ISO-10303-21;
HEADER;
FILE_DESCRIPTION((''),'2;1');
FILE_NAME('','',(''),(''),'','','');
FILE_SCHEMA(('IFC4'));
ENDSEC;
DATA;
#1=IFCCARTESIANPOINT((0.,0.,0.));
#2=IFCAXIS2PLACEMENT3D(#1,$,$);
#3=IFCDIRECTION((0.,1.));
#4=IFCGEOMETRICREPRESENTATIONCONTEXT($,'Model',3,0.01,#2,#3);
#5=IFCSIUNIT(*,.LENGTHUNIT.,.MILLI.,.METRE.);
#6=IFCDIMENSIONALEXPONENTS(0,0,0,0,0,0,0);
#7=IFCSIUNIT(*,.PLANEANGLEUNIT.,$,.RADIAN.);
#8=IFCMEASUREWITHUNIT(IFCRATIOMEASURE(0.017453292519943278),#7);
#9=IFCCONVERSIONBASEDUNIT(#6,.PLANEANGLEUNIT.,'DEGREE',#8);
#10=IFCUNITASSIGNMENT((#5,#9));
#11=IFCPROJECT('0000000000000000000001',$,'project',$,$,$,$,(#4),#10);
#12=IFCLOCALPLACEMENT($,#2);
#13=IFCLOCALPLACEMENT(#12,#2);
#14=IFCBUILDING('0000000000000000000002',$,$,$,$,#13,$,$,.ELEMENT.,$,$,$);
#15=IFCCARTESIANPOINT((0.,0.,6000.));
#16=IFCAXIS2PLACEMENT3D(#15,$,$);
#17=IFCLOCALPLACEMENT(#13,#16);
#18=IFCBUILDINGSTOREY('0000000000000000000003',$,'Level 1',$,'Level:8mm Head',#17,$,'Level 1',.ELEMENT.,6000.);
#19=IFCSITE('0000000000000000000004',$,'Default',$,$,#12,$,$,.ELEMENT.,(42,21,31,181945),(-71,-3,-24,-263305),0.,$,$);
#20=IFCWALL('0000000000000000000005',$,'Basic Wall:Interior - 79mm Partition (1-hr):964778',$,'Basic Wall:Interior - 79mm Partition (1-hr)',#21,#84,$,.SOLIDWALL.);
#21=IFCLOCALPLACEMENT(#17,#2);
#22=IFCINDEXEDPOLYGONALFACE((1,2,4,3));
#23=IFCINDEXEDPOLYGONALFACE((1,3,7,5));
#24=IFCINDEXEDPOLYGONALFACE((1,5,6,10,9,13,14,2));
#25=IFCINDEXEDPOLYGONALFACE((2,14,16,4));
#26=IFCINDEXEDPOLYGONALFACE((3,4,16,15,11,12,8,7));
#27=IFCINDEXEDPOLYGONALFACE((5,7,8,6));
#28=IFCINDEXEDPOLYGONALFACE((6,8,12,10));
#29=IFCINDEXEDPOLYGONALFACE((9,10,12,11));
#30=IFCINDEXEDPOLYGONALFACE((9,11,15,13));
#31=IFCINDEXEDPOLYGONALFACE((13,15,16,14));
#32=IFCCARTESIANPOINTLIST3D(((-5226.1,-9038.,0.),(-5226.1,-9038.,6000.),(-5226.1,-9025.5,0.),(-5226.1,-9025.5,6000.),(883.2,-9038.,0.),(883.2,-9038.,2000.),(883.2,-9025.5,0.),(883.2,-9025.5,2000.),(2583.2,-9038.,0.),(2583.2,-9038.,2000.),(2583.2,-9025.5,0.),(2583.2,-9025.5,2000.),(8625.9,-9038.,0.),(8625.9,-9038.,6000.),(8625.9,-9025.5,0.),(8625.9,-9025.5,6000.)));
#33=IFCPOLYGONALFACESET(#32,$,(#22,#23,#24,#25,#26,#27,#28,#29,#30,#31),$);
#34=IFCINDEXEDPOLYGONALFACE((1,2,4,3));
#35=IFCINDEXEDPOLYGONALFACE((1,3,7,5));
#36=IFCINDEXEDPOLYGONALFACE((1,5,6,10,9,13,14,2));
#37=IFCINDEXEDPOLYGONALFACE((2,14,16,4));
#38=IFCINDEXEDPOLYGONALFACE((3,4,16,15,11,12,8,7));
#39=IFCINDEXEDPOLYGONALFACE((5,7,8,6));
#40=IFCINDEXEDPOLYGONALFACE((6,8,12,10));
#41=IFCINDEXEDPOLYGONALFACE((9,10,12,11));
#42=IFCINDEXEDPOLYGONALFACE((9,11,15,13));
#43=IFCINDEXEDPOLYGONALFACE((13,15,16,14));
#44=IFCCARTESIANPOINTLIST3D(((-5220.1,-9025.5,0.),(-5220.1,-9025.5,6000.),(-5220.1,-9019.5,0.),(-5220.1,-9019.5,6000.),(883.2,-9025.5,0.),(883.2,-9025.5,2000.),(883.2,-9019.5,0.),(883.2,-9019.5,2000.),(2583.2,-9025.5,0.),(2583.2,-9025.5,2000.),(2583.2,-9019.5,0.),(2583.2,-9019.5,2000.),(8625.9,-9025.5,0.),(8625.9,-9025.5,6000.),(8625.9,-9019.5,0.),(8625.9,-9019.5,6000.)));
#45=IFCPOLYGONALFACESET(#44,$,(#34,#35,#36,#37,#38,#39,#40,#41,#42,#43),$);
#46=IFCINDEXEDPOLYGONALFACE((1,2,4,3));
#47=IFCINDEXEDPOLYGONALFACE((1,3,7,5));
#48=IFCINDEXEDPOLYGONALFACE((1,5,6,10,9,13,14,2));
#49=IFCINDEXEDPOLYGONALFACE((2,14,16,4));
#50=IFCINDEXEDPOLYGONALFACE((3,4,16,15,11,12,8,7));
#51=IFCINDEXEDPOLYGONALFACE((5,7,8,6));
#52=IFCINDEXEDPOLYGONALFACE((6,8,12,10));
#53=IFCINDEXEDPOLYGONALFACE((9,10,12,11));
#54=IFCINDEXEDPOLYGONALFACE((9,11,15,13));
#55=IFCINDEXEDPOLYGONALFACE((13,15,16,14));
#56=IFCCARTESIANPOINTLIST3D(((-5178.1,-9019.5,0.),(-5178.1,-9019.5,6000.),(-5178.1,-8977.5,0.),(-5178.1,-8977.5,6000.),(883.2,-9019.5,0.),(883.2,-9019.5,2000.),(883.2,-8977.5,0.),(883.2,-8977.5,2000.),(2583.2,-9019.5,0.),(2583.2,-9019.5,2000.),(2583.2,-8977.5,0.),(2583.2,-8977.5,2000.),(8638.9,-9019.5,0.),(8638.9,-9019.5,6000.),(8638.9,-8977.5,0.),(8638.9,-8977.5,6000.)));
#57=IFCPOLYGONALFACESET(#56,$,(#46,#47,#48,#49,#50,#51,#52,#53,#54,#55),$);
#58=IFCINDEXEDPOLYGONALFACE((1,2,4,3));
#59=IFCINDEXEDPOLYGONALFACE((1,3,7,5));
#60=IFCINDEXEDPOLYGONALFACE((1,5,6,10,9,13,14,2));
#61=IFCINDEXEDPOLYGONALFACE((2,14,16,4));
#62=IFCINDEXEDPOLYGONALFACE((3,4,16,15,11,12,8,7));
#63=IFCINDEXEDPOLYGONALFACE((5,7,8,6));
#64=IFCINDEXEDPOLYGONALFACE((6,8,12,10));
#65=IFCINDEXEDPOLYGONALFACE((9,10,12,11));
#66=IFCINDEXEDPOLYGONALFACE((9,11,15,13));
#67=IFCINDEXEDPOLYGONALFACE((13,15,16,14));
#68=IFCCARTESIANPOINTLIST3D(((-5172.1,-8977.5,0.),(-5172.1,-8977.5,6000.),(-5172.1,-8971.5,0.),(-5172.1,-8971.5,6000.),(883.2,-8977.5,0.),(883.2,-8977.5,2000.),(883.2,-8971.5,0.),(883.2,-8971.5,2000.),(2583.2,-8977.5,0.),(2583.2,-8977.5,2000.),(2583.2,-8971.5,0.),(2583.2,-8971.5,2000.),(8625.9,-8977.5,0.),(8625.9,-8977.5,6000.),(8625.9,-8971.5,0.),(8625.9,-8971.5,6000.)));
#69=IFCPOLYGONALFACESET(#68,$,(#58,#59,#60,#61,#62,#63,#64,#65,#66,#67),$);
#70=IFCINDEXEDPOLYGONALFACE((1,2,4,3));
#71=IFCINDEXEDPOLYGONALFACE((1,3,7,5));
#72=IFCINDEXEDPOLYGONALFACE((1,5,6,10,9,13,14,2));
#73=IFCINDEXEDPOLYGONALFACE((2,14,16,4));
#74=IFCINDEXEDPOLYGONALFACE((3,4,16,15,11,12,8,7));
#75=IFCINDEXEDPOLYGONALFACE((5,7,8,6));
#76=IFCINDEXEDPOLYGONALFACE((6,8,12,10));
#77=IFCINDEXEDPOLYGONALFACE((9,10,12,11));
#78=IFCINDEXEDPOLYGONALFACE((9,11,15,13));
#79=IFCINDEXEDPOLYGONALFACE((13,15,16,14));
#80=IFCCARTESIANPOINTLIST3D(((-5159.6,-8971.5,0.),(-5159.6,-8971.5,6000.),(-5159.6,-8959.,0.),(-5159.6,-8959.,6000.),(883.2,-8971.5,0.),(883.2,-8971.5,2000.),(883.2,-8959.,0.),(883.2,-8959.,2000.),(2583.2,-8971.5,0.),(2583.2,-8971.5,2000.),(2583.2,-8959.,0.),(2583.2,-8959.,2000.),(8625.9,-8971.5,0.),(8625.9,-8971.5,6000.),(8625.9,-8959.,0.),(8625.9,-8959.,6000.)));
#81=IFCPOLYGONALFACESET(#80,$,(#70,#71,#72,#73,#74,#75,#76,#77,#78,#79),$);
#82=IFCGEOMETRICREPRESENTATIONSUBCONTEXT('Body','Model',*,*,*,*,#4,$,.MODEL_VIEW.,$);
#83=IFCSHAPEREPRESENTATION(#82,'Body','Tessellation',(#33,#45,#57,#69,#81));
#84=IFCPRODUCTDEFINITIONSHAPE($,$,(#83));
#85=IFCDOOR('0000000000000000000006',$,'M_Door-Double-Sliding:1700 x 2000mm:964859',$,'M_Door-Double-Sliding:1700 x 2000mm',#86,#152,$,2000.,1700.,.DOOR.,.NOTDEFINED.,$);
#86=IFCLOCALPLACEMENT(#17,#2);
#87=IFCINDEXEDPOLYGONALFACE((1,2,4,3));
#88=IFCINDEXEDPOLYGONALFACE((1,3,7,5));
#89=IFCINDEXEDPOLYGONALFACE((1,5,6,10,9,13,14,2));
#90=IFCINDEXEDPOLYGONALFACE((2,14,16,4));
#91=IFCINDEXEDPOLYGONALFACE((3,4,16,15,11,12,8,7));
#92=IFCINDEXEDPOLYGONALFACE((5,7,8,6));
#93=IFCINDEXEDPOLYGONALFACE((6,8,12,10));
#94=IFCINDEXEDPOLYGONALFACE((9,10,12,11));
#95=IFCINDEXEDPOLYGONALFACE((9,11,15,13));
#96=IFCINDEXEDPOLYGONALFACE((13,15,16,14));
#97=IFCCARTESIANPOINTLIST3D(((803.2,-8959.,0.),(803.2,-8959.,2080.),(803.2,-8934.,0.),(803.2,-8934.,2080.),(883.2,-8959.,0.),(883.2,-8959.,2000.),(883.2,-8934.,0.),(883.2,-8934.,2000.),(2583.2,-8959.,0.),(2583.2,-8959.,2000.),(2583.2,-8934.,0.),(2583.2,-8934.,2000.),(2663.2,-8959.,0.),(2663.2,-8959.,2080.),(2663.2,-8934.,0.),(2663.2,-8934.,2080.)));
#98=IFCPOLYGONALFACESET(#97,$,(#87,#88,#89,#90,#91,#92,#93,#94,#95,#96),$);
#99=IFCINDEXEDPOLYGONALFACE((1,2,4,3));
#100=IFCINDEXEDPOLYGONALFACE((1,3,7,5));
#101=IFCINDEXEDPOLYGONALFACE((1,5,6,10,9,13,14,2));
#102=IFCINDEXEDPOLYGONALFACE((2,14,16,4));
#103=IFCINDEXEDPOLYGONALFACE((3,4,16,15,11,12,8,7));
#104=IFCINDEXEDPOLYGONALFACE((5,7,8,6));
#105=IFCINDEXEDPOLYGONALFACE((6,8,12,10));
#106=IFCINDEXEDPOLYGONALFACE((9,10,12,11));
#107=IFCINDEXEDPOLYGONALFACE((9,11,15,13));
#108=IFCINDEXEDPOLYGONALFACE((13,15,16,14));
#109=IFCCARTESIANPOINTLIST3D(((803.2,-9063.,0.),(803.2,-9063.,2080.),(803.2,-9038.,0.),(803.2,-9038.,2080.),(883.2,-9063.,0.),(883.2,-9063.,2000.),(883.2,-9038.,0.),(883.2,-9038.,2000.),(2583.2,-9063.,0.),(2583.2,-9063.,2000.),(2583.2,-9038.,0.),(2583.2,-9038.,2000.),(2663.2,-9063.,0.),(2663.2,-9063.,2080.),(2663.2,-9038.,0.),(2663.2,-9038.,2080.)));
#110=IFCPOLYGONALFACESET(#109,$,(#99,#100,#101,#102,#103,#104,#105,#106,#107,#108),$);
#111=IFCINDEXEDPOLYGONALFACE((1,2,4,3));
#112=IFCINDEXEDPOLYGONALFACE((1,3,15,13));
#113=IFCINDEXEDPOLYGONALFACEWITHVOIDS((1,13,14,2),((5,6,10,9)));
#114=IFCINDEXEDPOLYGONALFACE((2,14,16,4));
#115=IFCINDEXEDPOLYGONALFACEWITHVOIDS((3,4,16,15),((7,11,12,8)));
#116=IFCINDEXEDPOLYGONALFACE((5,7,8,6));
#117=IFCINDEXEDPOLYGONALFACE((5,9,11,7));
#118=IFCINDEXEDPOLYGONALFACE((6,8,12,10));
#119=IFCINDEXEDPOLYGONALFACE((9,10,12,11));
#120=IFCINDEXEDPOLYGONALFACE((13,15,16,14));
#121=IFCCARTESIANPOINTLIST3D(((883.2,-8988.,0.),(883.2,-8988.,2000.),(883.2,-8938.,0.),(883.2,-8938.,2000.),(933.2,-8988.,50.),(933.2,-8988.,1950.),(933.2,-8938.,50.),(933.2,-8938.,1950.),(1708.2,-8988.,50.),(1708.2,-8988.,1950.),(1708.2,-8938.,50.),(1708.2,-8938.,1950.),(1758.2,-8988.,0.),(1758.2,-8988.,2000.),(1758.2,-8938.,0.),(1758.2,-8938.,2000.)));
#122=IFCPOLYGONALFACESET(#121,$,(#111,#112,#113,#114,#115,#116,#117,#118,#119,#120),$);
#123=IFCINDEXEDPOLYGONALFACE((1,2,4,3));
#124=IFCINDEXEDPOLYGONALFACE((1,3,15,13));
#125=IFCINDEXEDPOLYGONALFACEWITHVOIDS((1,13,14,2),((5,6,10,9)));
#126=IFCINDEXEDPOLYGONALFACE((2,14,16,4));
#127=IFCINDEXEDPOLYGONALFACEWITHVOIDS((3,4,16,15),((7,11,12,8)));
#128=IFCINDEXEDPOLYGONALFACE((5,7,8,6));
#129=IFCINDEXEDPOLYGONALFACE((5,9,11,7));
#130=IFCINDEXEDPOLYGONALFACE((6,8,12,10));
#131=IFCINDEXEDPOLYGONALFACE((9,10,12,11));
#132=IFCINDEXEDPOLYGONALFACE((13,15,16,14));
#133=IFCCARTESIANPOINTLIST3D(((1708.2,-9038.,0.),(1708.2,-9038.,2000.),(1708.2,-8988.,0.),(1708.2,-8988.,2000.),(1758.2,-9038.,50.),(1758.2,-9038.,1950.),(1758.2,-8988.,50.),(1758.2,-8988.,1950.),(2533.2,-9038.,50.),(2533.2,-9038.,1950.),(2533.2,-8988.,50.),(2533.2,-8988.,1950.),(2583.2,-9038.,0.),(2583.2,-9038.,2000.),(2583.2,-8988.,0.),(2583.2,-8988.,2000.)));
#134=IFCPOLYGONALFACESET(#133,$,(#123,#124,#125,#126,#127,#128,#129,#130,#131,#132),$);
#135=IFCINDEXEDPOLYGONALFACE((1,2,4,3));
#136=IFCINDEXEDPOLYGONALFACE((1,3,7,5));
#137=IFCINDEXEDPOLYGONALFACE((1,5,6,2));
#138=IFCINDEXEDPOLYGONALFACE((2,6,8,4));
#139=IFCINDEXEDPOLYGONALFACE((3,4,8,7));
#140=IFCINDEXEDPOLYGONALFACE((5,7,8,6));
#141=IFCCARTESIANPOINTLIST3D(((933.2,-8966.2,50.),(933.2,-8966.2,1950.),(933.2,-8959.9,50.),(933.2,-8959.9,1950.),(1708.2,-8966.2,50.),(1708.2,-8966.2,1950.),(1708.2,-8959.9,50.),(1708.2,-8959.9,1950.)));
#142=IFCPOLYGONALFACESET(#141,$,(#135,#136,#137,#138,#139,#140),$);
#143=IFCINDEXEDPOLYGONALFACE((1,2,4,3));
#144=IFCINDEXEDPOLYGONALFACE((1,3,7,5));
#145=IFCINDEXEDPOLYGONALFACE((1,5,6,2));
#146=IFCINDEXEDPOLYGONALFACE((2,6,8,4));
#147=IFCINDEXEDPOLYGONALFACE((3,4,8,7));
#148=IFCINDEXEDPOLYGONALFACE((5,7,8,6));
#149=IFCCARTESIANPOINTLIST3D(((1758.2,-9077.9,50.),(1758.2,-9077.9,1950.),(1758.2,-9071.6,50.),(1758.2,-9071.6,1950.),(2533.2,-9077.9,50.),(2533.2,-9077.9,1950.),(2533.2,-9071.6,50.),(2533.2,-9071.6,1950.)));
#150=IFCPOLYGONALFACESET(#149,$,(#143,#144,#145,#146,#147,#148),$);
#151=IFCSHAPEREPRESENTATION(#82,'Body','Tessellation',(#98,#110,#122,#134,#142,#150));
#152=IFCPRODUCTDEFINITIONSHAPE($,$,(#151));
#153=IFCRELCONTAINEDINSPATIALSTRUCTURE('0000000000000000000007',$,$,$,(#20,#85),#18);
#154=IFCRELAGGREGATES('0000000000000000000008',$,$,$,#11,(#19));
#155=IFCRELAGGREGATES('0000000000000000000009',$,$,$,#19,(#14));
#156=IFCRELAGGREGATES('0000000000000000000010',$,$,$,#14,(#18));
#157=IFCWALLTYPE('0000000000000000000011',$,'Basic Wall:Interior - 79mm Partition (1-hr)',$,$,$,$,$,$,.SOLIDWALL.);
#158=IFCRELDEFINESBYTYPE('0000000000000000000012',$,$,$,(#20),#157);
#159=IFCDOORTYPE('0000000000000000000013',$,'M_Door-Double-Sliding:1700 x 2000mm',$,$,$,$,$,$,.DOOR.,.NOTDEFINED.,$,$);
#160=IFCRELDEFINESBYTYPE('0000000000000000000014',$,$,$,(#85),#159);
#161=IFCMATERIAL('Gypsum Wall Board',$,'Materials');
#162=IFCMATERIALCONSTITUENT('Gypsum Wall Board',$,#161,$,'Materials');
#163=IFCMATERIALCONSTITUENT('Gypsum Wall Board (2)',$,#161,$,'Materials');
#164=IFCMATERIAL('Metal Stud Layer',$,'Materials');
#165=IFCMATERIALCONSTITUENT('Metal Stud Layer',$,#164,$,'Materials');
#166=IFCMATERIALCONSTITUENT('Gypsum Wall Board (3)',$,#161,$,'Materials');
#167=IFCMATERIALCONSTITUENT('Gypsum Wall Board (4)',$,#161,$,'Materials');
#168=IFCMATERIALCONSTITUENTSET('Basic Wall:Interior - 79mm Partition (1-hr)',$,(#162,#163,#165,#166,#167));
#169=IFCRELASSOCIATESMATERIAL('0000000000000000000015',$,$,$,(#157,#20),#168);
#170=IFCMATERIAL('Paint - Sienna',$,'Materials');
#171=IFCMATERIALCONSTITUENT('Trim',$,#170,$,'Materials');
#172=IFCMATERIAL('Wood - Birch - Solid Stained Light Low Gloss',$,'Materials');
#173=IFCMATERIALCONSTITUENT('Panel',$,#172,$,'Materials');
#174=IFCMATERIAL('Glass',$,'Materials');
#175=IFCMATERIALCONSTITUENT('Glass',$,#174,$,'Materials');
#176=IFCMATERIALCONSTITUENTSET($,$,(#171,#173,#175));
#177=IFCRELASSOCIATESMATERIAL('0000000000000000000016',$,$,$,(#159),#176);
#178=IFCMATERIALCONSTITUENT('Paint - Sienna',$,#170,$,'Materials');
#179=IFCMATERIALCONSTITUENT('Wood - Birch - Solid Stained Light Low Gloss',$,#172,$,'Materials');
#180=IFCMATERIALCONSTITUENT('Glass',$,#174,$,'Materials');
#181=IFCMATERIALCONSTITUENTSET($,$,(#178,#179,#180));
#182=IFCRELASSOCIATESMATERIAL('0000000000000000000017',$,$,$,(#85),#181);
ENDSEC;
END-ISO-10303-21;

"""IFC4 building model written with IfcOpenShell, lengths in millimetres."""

from ifc_helpers import new_model, entity, si_unit, converted_unit, direction, frame, origin, place, context, subcontext, project, spatial, indexed_curve, outline, extrude, source, transform, mapped, material, constituent, constituent_set, type_object, type_shapes, element, fill, save


model = new_model("IFC4")

# Units and contexts
model_context = context("Model", 3, precision=0.01, world=origin(), true_north=direction((0.0, 1.0)))
body_context = subcontext(model_context, "Body", "Model", "MODEL_VIEW")
ifc_project = project(units=[si_unit("LENGTHUNIT", "METRE", prefix="MILLI"), converted_unit("PLANEANGLEUNIT", "DEGREE", entity("IfcRatioMeasure", 0.017453292519943278), si_unit("PLANEANGLEUNIT", "RADIAN"), dimensions=[0, 0, 0, 0, 0, 0, 0])], contexts=[model_context])

# Site, building, storey
site_placement = place(None, origin())
site = spatial("IfcSite", under=ifc_project, at=site_placement, Name="Default", CompositionType="ELEMENT", RefLatitude=(42, 21, 31, 181945), RefLongitude=(-71, -3, -24, -263305), RefElevation=0.0)
building_placement = place(site_placement, origin())
building = spatial("IfcBuilding", under=site, at=building_placement, CompositionType="ELEMENT")
storey_placement = place(building_placement, frame((0.0, 0.0, 6000.0)))
storey = spatial("IfcBuildingStorey", under=building, at=storey_placement, Name="Level 1", ObjectType="Level:8mm Head", LongName="Level 1", CompositionType="ELEMENT", Elevation=6000.0)

# Shared definitions
ifc_material_1 = material(Name="Gypsum Wall Board", Category="Materials")
ifc_constituent_1 = constituent(ifc_material_1, Name="Gypsum Wall Board", Category="Materials")
ifc_constituent_2 = constituent(ifc_material_1, Name="Gypsum Wall Board (2)", Category="Materials")
ifc_material_2 = material(Name="Metal Stud Layer", Category="Materials")
ifc_constituent_3 = constituent(ifc_material_2, Name="Metal Stud Layer", Category="Materials")
ifc_constituent_4 = constituent(ifc_material_1, Name="Gypsum Wall Board (3)", Category="Materials")
ifc_constituent_5 = constituent(ifc_material_1, Name="Gypsum Wall Board (4)", Category="Materials")
ifc_constituent_set_1 = constituent_set(constituents=[ifc_constituent_1, ifc_constituent_2, ifc_constituent_3, ifc_constituent_4, ifc_constituent_5], Name="Basic Wall:Interior - 79mm Partition (1-hr)")
wall_type = type_object("IfcWallType", Name="Basic Wall:Interior - 79mm Partition (1-hr)", PredefinedType="SOLIDWALL", material=ifc_constituent_set_1)

# Wall, opening, door
ifc_material_3 = material(Name="Paint - Sienna", Category="Materials")
ifc_material_4 = material(Name="Wood - Birch - Solid Stained Light Low Gloss", Category="Materials")
ifc_material_5 = material(Name="Glass", Category="Materials")
ifc_constituent_6 = constituent(ifc_material_3, Name="Trim", Category="Materials")
ifc_constituent_7 = constituent(ifc_material_4, Name="Panel", Category="Materials")
ifc_constituent_8 = constituent(ifc_material_5, Name="Glass", Category="Materials")
ifc_constituent_set_2 = constituent_set(constituents=[ifc_constituent_6, ifc_constituent_7, ifc_constituent_8])
door_type = type_object("IfcDoorType", Name="M_Door-Double-Sliding:1700 x 2000mm", OperationType="NOTDEFINED", PredefinedType="DOOR", material=ifc_constituent_set_2)
shared_shape_1 = source(origin(), body_context, "Body", "SweptSolid", [
    extrude(outline(indexed_curve([(-1020.0, -930.0), (1060.0, -930.0), (1060.0, 930.0), (-1020.0, 930.0), (-1020.0, 850.0), (980.0, 850.0), (980.0, -850.0), (-1020.0, -850.0), (-1020.0, -930.0)], self_intersect=False)), frame((850.0, -25.0, 1020.0), z_axis=(0.0, 1.0, 0.0), x_axis=(0.0, 0.0, 1.0)), (0.0, 0.0, 1.0), 25.0),
    extrude(outline(indexed_curve([(-930.0, -1020.0), (-850.0, -1020.0), (-850.0, 980.0), (850.0, 980.0), (850.0, -1020.0), (930.0, -1020.0), (930.0, 1060.0), (-930.0, 1060.0), (-930.0, -1020.0)], self_intersect=False)), frame((850.0, 79.0, 1020.0), z_axis=(0.0, 1.0, 0.0), x_axis=(-1.0, 0.0, 0.0)), (0.0, 0.0, 1.0), 25.0),
    extrude(outline(indexed_curve([(-437.5, -1000.0), (437.5, -1000.0), (437.5, 1000.0), (-437.5, 1000.0), (-437.5, -1000.0)], self_intersect=False), holes=[indexed_curve([(-387.5, -950.0), (-387.5, 950.0), (387.5, 950.0), (387.5, -950.0), (-387.5, -950.0)], self_intersect=False)]), frame((1262.5, -21.0, 1000.0), z_axis=(0.0, 1.0, 0.0), x_axis=(1.0, 0.0, 0.0)), (0.0, 0.0, 1.0), 50.0),
    extrude(outline(indexed_curve([(-1000.0, -437.5), (1000.0, -437.5), (1000.0, 437.5), (-1000.0, 437.5), (-1000.0, -437.5)], self_intersect=False), holes=[indexed_curve([(-950.0, -387.5), (-950.0, 387.5), (950.0, 387.5), (950.0, -387.5), (-950.0, -387.5)], self_intersect=False)]), frame((437.5, 29.0, 1000.0), z_axis=(0.0, 1.0, 0.0), x_axis=(0.0, 0.0, -1.0)), (0.0, 0.0, 1.0), 50.0),
    extrude(outline(indexed_curve([(-3.2, -387.5), (3.2, -387.5), (3.2, 387.5), (-3.2, 387.5), (-3.2, -387.5)], self_intersect=False)), frame((1262.5, 4.0, 50.0), z_axis=(0.0, 0.0, 1.0), x_axis=(0.0, -1.0, 0.0)), (0.0, 0.0, 1.0), 1900.0),
    extrude(outline(indexed_curve([(-3.2, -387.5), (3.2, -387.5), (3.2, 387.5), (-3.2, 387.5), (-3.2, -387.5)], self_intersect=False)), frame((437.5, 115.7, 50.0), z_axis=(0.0, 0.0, 1.0), x_axis=(0.0, 1.0, 0.0)), (0.0, 0.0, 1.0), 1900.0),
])
type_shapes(door_type, [shared_shape_1])
wall_1_placement = place(storey_placement, frame((-5159.6, -8998.5, 0.0)))
wall_1 = element("IfcWall", 1, at=wall_1_placement, inside=storey, type_object=wall_type, material=ifc_constituent_set_1, Name="Basic Wall:Interior - 79mm Partition (1-hr):964778", ObjectType="Basic Wall:Interior - 79mm Partition (1-hr)", PredefinedType="SOLIDWALL", context=body_context, shape_type="SweptSolid", body=[
    extrude(outline(indexed_curve([(-2000.0, -6942.6), (4000.0, -6942.6), (4000.0, 6909.4), (-2000.0, 6909.4), (-2000.0, 866.6), (0.0, 866.6), (0.0, -833.4), (-2000.0, -833.4), (-2000.0, -6942.6)], self_intersect=False)), frame((6876.1, -39.5, 2000.0), z_axis=(0.0, 1.0, 0.0), x_axis=(0.0, 0.0, 1.0)), (0.0, 0.0, 1.0), 12.5),
    extrude(outline(indexed_curve([(-2000.0, -865.1), (-2000.0, -6907.9), (4000.0, -6907.9), (4000.0, 6938.1), (-2000.0, 6938.1), (-2000.0, 834.9), (0.0, 834.9), (0.0, -865.1), (-2000.0, -865.1)], self_intersect=False)), frame((6877.6, -27.0, 2000.0), z_axis=(0.0, -1.0, 0.0), x_axis=(0.0, 0.0, 1.0)), (0.0, 0.0, -1.0), 6.0),
    extrude(outline(indexed_curve([(-2000.0, -851.4), (-2000.0, -6907.1), (4000.0, -6907.1), (4000.0, 6909.9), (-2000.0, 6909.9), (-2000.0, 848.6), (0.0, 848.6), (0.0, -851.4), (-2000.0, -851.4)], self_intersect=False)), frame((6891.4, -21.0, 2000.0), z_axis=(0.0, -1.0, 0.0), x_axis=(0.0, 0.0, 1.0)), (0.0, 0.0, -1.0), 42.0),
    extrude(outline(indexed_curve([(-2000.0, -853.1), (-2000.0, -6895.9), (4000.0, -6895.9), (4000.0, 6902.1), (-2000.0, 6902.1), (-2000.0, 846.9), (0.0, 846.9), (0.0, -853.1), (-2000.0, -853.1)], self_intersect=False)), frame((6889.6, 21.0, 2000.0), z_axis=(0.0, -1.0, 0.0), x_axis=(0.0, 0.0, 1.0)), (0.0, 0.0, -1.0), 6.0),
    extrude(outline(indexed_curve([(-2000.0, -850.0), (-2000.0, -6892.8), (4000.0, -6892.8), (4000.0, 6892.8), (-2000.0, 6892.8), (-2000.0, 850.0), (0.0, 850.0), (0.0, -850.0), (-2000.0, -850.0)], self_intersect=False)), frame((6892.8, 27.0, 2000.0), z_axis=(0.0, -1.0, 0.0), x_axis=(0.0, 0.0, 1.0)), (0.0, 0.0, -1.0), 12.5),
])
opening_1_placement = place(wall_1_placement, frame((7742.8, 39.5, 0.0)))
opening_1 = element("IfcOpeningElement", 2, at=opening_1_placement, cuts=wall_1, PredefinedType="OPENING", context=body_context, shape_type="SweptSolid", body=[
    extrude(outline(indexed_curve([(2000.0, 0.0), (2000.0, 1700.0), (0.0, 1700.0), (0.0, 0.0), (2000.0, 0.0)], self_intersect=False)), frame((0.0, 0.0, 0.0), z_axis=(0.0, -1.0, 0.0), x_axis=(0.0, 0.0, 1.0)), (0.0, 0.0, 1.0), 79.0),
])
ifc_constituent_9 = constituent(ifc_material_3, Name="Paint - Sienna", Category="Materials")
ifc_constituent_10 = constituent(ifc_material_4, Name="Wood - Birch - Solid Stained Light Low Gloss", Category="Materials")
ifc_constituent_11 = constituent(ifc_material_5, Name="Glass", Category="Materials")
ifc_constituent_set_3 = constituent_set(constituents=[ifc_constituent_9, ifc_constituent_10, ifc_constituent_11])
door_1_placement = place(opening_1_placement, frame((0.0, 0.0, 0.0), z_axis=(0.0, 0.0, 1.0), x_axis=(-1.0, 0.0, 0.0)))
door_1 = element("IfcDoor", 3, at=door_1_placement, inside=storey, type_object=door_type, material=ifc_constituent_set_3, Name="M_Door-Double-Sliding:1700 x 2000mm:964859", ObjectType="M_Door-Double-Sliding:1700 x 2000mm", OperationType="NOTDEFINED", OverallHeight=2000.0, OverallWidth=1700.0, PredefinedType="DOOR", context=body_context, shape_type="MappedRepresentation", body=[
    mapped(shared_shape_1, transform((0.0, 0.0, 0.0), scale=1.0)),
])
fill(opening_1, door_1)

save(model, "model.ifc")
